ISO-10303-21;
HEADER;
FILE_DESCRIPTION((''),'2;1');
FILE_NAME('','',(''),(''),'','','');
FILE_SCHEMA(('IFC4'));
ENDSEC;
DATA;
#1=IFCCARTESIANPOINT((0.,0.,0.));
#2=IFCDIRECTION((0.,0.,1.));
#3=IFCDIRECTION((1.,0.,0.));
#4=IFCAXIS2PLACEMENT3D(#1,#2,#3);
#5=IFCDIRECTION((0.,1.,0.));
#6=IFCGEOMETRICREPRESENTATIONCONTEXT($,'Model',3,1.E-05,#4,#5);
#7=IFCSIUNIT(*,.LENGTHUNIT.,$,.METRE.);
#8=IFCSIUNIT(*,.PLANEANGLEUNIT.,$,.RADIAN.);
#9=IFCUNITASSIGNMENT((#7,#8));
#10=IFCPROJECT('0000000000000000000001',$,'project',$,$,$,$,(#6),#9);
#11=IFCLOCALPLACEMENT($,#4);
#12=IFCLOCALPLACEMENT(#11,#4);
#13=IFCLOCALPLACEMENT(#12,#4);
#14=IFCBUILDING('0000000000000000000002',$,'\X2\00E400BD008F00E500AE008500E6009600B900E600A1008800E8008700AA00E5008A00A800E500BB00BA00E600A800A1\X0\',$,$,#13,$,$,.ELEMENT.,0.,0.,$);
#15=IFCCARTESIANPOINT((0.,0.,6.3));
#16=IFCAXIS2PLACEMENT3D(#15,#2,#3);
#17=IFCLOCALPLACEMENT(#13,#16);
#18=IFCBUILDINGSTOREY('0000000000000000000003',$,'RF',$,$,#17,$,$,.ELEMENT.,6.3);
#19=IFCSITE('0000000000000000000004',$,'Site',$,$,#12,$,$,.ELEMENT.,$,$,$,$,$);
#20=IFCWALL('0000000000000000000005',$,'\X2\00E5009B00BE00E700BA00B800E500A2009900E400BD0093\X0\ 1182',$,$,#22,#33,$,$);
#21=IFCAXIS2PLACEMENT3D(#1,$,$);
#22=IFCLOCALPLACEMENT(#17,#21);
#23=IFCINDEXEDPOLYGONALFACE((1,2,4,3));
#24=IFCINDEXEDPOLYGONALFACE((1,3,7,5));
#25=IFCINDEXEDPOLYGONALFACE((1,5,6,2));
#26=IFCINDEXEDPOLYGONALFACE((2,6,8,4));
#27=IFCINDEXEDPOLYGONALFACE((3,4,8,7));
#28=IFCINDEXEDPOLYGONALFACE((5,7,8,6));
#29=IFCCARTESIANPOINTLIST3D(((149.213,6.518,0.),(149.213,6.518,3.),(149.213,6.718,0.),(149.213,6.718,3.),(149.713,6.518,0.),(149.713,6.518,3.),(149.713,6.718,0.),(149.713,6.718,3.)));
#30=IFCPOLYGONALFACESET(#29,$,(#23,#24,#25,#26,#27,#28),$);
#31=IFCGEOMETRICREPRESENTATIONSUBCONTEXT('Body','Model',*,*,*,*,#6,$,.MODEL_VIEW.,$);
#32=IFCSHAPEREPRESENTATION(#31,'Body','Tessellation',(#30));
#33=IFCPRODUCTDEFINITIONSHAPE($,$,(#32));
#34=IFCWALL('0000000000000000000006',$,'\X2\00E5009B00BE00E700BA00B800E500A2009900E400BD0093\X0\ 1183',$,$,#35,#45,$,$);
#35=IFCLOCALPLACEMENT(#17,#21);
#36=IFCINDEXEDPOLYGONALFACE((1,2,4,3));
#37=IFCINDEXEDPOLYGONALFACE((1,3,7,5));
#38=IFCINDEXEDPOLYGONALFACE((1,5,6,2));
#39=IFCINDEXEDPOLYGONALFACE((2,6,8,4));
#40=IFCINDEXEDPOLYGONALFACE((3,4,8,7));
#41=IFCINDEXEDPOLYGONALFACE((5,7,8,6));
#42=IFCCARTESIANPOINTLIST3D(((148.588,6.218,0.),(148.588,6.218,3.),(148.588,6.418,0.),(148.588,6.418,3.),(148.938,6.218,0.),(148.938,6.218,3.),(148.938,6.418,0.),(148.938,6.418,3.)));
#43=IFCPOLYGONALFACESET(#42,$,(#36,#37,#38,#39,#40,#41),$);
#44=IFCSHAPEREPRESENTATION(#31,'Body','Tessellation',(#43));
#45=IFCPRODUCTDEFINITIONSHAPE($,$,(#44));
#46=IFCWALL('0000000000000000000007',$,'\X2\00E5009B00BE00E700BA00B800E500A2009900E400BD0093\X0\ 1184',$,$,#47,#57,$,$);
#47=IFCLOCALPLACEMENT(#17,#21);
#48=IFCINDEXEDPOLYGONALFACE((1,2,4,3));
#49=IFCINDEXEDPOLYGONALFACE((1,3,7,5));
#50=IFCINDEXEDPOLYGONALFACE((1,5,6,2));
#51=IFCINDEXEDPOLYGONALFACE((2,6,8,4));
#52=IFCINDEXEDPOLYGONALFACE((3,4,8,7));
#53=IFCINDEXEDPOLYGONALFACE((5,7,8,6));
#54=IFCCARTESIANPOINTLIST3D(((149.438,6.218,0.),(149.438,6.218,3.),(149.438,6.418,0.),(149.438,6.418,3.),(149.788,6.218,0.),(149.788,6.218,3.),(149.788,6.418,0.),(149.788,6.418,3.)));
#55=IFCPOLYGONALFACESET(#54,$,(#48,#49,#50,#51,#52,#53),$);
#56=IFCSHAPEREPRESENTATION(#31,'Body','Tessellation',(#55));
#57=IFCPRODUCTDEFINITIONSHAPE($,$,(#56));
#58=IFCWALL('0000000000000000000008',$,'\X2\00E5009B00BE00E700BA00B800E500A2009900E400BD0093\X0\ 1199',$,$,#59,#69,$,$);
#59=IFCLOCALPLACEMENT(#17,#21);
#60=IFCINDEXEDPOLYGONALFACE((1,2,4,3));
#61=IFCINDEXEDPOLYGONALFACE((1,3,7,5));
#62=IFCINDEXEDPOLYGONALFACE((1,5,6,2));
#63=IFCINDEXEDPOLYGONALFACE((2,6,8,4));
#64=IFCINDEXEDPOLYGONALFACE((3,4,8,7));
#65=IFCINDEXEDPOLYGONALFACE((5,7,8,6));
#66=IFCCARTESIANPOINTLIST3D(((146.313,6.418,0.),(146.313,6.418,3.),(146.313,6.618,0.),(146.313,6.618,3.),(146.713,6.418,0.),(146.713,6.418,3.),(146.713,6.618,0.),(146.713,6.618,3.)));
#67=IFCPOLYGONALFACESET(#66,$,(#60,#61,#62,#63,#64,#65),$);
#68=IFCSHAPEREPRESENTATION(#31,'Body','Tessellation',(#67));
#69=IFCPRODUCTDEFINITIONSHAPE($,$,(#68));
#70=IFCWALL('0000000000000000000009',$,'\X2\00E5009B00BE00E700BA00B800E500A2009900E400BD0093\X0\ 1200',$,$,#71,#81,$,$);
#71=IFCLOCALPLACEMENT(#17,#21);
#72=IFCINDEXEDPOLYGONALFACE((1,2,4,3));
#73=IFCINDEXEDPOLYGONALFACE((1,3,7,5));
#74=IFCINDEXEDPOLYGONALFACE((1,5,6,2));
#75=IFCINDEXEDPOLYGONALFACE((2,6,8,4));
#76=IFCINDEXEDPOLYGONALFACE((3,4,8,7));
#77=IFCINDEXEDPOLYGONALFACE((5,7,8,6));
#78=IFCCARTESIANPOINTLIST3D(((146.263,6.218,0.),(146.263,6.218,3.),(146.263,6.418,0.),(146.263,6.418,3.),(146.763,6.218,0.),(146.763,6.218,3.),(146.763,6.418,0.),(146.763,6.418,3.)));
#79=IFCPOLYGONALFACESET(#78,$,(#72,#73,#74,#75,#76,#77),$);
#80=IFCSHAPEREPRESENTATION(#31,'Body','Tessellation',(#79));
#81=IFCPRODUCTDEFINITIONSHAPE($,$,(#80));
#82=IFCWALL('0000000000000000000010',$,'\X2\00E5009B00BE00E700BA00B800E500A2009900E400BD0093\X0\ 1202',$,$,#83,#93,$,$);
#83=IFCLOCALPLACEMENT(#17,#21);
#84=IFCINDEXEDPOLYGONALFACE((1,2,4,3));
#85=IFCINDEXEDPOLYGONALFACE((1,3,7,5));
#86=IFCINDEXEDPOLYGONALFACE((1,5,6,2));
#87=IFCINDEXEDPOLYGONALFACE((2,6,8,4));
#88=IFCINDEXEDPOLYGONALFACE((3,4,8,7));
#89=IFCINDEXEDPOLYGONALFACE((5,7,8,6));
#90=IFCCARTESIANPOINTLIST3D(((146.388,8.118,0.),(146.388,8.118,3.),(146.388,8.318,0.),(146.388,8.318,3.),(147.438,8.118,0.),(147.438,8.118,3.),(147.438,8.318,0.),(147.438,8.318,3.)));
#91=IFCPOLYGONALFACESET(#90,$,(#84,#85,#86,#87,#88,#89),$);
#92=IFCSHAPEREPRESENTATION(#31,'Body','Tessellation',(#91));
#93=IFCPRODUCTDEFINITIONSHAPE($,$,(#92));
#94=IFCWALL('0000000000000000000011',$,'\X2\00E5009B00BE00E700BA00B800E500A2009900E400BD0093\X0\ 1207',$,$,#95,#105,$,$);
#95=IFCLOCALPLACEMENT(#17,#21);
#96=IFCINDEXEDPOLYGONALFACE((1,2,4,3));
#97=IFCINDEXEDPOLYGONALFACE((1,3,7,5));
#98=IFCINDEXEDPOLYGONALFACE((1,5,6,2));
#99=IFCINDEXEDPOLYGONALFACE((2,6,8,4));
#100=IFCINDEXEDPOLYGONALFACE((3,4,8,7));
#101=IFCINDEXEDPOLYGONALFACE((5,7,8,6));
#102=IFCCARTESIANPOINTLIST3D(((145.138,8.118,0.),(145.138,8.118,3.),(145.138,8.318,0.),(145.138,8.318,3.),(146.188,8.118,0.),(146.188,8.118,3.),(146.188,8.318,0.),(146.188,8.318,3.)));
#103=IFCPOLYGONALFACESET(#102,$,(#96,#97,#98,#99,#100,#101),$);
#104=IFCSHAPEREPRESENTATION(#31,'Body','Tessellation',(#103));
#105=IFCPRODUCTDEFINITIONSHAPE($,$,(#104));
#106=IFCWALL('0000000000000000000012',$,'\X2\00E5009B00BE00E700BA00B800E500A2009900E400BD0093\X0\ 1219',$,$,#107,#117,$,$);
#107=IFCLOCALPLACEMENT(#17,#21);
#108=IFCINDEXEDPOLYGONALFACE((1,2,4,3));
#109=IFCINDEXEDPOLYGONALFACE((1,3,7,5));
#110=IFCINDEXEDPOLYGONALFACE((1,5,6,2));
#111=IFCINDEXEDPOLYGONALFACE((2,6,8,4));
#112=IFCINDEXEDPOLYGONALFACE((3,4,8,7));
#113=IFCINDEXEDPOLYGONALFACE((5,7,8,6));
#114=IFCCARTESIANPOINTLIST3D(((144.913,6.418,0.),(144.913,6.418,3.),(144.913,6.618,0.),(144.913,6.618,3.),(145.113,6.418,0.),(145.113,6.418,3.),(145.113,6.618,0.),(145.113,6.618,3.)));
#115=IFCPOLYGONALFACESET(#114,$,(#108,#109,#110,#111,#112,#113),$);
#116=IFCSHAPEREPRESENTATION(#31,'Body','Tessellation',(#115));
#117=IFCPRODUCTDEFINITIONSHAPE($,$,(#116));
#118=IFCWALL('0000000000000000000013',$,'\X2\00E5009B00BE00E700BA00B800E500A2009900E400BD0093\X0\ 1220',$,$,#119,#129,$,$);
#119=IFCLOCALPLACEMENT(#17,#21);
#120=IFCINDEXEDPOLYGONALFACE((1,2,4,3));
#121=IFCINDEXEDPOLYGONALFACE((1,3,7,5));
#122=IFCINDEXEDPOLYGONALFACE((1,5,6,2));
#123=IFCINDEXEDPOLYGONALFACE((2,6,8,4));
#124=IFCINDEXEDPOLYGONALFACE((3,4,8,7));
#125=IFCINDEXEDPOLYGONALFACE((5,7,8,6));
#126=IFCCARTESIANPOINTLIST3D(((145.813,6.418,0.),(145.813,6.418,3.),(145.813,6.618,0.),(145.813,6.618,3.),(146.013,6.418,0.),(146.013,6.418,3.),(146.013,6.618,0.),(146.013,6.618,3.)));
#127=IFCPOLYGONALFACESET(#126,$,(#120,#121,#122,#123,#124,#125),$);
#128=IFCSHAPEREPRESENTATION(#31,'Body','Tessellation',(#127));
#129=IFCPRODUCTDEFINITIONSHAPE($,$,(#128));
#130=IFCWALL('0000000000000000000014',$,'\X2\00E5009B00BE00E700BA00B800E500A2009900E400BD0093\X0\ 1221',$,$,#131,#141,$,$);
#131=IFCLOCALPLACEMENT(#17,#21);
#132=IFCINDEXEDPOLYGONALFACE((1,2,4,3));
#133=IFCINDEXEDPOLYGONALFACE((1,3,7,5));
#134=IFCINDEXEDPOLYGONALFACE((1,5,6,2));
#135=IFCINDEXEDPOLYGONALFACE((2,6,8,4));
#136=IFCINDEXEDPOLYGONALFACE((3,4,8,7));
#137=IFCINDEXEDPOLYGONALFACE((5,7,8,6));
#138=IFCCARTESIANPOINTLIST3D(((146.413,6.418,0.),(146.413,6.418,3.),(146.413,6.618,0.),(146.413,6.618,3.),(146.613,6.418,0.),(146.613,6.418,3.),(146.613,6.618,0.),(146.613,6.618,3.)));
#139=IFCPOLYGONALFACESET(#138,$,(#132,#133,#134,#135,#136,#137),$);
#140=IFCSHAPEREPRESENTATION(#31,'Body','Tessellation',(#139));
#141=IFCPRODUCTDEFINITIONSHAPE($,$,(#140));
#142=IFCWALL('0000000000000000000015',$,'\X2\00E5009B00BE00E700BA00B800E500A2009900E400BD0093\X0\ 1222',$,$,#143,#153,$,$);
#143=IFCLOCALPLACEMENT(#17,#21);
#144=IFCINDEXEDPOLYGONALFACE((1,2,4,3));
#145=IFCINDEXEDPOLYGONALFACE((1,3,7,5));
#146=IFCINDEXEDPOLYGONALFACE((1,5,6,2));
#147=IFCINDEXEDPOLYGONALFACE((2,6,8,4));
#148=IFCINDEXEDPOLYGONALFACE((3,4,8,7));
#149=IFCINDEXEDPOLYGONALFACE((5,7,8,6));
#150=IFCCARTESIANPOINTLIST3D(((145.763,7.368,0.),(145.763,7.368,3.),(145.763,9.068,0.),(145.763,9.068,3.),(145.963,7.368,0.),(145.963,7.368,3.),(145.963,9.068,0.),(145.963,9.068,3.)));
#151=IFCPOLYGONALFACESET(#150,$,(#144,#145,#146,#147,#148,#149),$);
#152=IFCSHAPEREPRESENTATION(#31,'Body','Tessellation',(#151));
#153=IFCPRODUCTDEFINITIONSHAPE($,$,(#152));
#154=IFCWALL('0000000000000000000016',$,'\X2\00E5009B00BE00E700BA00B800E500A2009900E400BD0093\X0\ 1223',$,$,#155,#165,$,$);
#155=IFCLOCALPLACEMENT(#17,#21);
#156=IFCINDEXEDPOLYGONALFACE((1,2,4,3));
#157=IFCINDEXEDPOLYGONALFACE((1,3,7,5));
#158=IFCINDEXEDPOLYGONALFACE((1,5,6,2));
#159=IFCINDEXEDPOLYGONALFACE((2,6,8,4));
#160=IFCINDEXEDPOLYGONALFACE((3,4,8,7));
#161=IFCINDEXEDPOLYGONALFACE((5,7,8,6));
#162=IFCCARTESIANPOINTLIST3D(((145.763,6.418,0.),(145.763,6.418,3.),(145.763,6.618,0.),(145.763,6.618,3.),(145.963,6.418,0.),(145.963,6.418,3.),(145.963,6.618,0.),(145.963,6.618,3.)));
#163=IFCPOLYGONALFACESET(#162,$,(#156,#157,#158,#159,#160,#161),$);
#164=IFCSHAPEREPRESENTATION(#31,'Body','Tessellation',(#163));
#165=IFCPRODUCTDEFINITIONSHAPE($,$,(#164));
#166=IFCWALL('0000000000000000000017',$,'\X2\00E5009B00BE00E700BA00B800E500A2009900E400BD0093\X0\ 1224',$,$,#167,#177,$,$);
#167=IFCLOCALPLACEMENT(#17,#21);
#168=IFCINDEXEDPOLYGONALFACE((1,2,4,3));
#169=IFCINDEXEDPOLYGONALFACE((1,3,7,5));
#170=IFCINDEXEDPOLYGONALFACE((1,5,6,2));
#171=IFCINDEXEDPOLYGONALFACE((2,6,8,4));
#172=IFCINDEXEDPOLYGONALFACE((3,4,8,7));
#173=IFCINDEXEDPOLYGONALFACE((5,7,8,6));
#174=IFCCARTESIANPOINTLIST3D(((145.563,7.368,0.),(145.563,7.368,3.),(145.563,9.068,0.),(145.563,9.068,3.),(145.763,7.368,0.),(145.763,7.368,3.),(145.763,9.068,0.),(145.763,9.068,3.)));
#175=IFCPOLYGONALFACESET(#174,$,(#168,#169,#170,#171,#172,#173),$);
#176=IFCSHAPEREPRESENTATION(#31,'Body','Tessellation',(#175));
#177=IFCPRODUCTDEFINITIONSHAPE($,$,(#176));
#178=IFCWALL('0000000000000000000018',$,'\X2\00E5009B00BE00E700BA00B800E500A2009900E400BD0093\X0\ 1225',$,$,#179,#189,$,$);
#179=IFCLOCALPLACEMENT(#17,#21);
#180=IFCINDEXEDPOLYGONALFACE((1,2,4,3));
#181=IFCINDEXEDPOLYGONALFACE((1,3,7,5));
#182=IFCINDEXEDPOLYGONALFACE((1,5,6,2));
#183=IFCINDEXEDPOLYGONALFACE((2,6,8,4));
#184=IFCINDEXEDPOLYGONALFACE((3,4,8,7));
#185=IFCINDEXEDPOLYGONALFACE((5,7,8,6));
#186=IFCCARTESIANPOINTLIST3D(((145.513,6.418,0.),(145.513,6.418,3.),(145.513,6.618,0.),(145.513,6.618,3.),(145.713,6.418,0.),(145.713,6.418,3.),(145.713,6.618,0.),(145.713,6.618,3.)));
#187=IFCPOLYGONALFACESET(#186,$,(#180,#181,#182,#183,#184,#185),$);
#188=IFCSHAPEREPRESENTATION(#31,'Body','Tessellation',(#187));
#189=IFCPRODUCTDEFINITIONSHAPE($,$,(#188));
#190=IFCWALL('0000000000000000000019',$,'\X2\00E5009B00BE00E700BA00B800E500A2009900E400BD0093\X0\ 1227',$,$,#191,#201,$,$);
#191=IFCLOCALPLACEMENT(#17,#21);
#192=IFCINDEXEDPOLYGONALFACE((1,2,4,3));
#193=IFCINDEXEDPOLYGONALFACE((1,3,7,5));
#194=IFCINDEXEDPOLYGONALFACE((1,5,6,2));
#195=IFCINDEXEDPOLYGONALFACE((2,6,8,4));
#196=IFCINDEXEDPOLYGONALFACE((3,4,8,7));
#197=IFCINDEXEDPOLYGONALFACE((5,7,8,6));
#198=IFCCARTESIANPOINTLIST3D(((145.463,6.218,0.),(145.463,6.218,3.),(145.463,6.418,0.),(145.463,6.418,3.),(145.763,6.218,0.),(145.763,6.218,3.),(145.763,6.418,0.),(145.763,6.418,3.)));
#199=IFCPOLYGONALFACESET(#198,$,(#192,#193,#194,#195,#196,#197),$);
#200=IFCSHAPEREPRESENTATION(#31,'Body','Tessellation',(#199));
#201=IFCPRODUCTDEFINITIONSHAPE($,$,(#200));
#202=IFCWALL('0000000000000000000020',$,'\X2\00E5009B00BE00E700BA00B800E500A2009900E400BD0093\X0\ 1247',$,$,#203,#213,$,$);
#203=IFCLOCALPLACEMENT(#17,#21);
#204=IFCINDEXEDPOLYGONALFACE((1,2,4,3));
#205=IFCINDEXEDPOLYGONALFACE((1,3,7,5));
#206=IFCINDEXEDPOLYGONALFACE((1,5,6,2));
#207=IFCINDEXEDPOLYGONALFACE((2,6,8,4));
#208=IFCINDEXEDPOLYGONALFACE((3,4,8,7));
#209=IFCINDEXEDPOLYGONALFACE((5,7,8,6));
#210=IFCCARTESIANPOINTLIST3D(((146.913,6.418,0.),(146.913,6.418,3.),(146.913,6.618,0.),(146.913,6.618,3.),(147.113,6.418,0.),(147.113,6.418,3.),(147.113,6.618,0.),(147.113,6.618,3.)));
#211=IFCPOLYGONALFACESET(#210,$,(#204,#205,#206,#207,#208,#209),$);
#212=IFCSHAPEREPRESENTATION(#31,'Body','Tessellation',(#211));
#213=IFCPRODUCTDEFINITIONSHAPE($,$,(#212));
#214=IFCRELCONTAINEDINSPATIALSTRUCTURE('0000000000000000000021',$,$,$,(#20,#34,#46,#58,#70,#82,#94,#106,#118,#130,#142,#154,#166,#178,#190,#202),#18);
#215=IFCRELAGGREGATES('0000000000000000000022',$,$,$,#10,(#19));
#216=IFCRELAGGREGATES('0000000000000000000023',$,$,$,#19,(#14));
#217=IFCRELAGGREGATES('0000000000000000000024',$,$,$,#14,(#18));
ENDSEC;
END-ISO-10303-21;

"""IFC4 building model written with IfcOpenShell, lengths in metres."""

from ifc_helpers import new_model, si_unit, direction, frame, frame_2d, origin_with_axes, place, context, subcontext, project, spatial, rectangle, extrude, element, save


model = new_model("IFC4")

# Units and contexts
model_context = context("Model", 3, precision=1e-05, world=origin_with_axes(), true_north=direction((0.0, 1.0, 0.0)))
body_context = subcontext(model_context, "Body", "Model", "MODEL_VIEW")
ifc_project = project(units=[si_unit("LENGTHUNIT", "METRE"), si_unit("PLANEANGLEUNIT", "RADIAN")], contexts=[model_context])

# Site, building, storey
placement = place(None, origin_with_axes())
site_placement = place(placement, origin_with_axes())
site = spatial("IfcSite", under=ifc_project, at=site_placement, Name="Site", CompositionType="ELEMENT")
building_placement = place(site_placement, origin_with_axes())
building = spatial("IfcBuilding", under=site, at=building_placement, Name="ä½\u008få®\u0085æ\u0096¹æ¡\u0088è\u0087ªå\u008a¨å»ºæ¨¡", CompositionType="ELEMENT", ElevationOfRefHeight=0.0, ElevationOfTerrain=0.0)
storey_placement = place(building_placement, frame((0.0, 0.0, 6.3), z_axis=(0.0, 0.0, 1.0), x_axis=(1.0, 0.0, 0.0)))
storey = spatial("IfcBuildingStorey", under=building, at=storey_placement, Name="RF", CompositionType="ELEMENT", Elevation=6.3)

# Walls
wall_1_placement = place(storey_placement, frame((149.463, 6.618, 0.0), z_axis=(0.0, 0.0, 1.0), x_axis=(1.0, 0.0, 0.0)))
element("IfcWall", 1, at=wall_1_placement, inside=storey, Name="å\u009b¾çº¸å¢\u0099ä½\u0093 1182", context=body_context, shape_type="SweptSolid", body=[
    extrude(rectangle(XDim=0.5, YDim=0.2, at=frame_2d((0.0, 0.0), x_axis=(1.0, 0.0, 0.0))), frame((0.0, 0.0, 0.0), z_axis=(0.0, 0.0, 1.0)), (0.0, 0.0, 1.0), 3.0),
])
for number, where, z_axis, x_axis, name in (
    (2, (148.763, 6.318, 0.0), (0.0, 0.0, 1.0), (1.0, 0.0, 0.0), "å\u009b¾çº¸å¢\u0099ä½\u0093 1183"),
    (3, (149.613, 6.318, 0.0), (0.0, 0.0, 1.0), (1.0, 0.0, 0.0), "å\u009b¾çº¸å¢\u0099ä½\u0093 1184"),
):
    element("IfcWall", number, at=place(storey_placement, frame(where, z_axis=z_axis, x_axis=x_axis)), inside=storey, Name=name, context=body_context, shape_type="SweptSolid", body=[
        extrude(rectangle(XDim=0.35, YDim=0.2, at=frame_2d((0.0, 0.0), x_axis=(1.0, 0.0, 0.0))), frame((0.0, 0.0, 0.0), z_axis=(0.0, 0.0, 1.0)), (0.0, 0.0, 1.0), 3.0),
    ])
wall_2_placement = place(storey_placement, frame((146.513, 6.518, 0.0), z_axis=(0.0, 0.0, 1.0), x_axis=(1.0, 0.0, 0.0)))
element("IfcWall", 4, at=wall_2_placement, inside=storey, Name="å\u009b¾çº¸å¢\u0099ä½\u0093 1199", context=body_context, shape_type="SweptSolid", body=[
    extrude(rectangle(XDim=0.4, YDim=0.2, at=frame_2d((0.0, 0.0), x_axis=(1.0, 0.0, 0.0))), frame((0.0, 0.0, 0.0), z_axis=(0.0, 0.0, 1.0)), (0.0, 0.0, 1.0), 3.0),
])
wall_3_placement = place(storey_placement, frame((146.513, 6.318, 0.0), z_axis=(0.0, 0.0, 1.0), x_axis=(1.0, 0.0, 0.0)))
element("IfcWall", 5, at=wall_3_placement, inside=storey, Name="å\u009b¾çº¸å¢\u0099ä½\u0093 1200", context=body_context, shape_type="SweptSolid", body=[
    extrude(rectangle(XDim=0.5, YDim=0.2, at=frame_2d((0.0, 0.0), x_axis=(1.0, 0.0, 0.0))), frame((0.0, 0.0, 0.0), z_axis=(0.0, 0.0, 1.0)), (0.0, 0.0, 1.0), 3.0),
])
for number, where, z_axis, x_axis, name in (
    (6, (146.913, 8.218, 0.0), (0.0, 0.0, 1.0), (-1.0, 0.0, 0.0), "å\u009b¾çº¸å¢\u0099ä½\u0093 1202"),
    (7, (145.663, 8.218, 0.0), (0.0, 0.0, 1.0), (-1.0, 0.0, 0.0), "å\u009b¾çº¸å¢\u0099ä½\u0093 1207"),
):
    element("IfcWall", number, at=place(storey_placement, frame(where, z_axis=z_axis, x_axis=x_axis)), inside=storey, Name=name, context=body_context, shape_type="SweptSolid", body=[
        extrude(rectangle(XDim=1.05, YDim=0.2, at=frame_2d((0.0, 0.0), x_axis=(1.0, 0.0, 0.0))), frame((0.0, 0.0, 0.0), z_axis=(0.0, 0.0, 1.0)), (0.0, 0.0, 1.0), 3.0),
    ])
for number, where, z_axis, x_axis, name in (
    (8, (145.013, 6.518, 0.0), (0.0, 0.0, 1.0), (0.0, -1.0, 0.0), "å\u009b¾çº¸å¢\u0099ä½\u0093 1219"),
    (9, (145.913, 6.518, 0.0), (0.0, 0.0, 1.0), (0.0, -1.0, 0.0), "å\u009b¾çº¸å¢\u0099ä½\u0093 1220"),
    (10, (146.513, 6.518, 0.0), (0.0, 0.0, 1.0), (0.0, -1.0, 0.0), "å\u009b¾çº¸å¢\u0099ä½\u0093 1221"),
):
    element("IfcWall", number, at=place(storey_placement, frame(where, z_axis=z_axis, x_axis=x_axis)), inside=storey, Name=name, context=body_context, shape_type="SweptSolid", body=[
        extrude(rectangle(XDim=0.2, YDim=0.2, at=frame_2d((0.0, 0.0), x_axis=(1.0, 0.0, 0.0))), frame((0.0, 0.0, 0.0), z_axis=(0.0, 0.0, 1.0)), (0.0, 0.0, 1.0), 3.0),
    ])
wall_4_placement = place(storey_placement, frame((145.863, 8.218, 0.0), z_axis=(0.0, 0.0, 1.0), x_axis=(0.0, -1.0, 0.0)))
element("IfcWall", 11, at=wall_4_placement, inside=storey, Name="å\u009b¾çº¸å¢\u0099ä½\u0093 1222", context=body_context, shape_type="SweptSolid", body=[
    extrude(rectangle(XDim=1.7, YDim=0.2, at=frame_2d((0.0, 0.0), x_axis=(1.0, 0.0, 0.0))), frame((0.0, 0.0, 0.0), z_axis=(0.0, 0.0, 1.0)), (0.0, 0.0, 1.0), 3.0),
])
wall_5_placement = place(storey_placement, frame((145.863, 6.518, 0.0), z_axis=(0.0, 0.0, 1.0), x_axis=(1.0, 0.0, 0.0)))
element("IfcWall", 12, at=wall_5_placement, inside=storey, Name="å\u009b¾çº¸å¢\u0099ä½\u0093 1223", context=body_context, shape_type="SweptSolid", body=[
    extrude(rectangle(XDim=0.2, YDim=0.2, at=frame_2d((0.0, 0.0), x_axis=(1.0, 0.0, 0.0))), frame((0.0, 0.0, 0.0), z_axis=(0.0, 0.0, 1.0)), (0.0, 0.0, 1.0), 3.0),
])
wall_6_placement = place(storey_placement, frame((145.663, 8.218, 0.0), z_axis=(0.0, 0.0, 1.0), x_axis=(0.0, -1.0, 0.0)))
element("IfcWall", 13, at=wall_6_placement, inside=storey, Name="å\u009b¾çº¸å¢\u0099ä½\u0093 1224", context=body_context, shape_type="SweptSolid", body=[
    extrude(rectangle(XDim=1.7, YDim=0.2, at=frame_2d((0.0, 0.0), x_axis=(1.0, 0.0, 0.0))), frame((0.0, 0.0, 0.0), z_axis=(0.0, 0.0, 1.0)), (0.0, 0.0, 1.0), 3.0),
])
for number, where, z_axis, x_axis, name in (
    (14, (145.613, 6.518, 0.0), (0.0, 0.0, 1.0), (1.0, 0.0, 0.0), "å\u009b¾çº¸å¢\u0099ä½\u0093 1225"),
):
    element("IfcWall", number, at=place(storey_placement, frame(where, z_axis=z_axis, x_axis=x_axis)), inside=storey, Name=name, context=body_context, shape_type="SweptSolid", body=[
        extrude(rectangle(XDim=0.2, YDim=0.2, at=frame_2d((0.0, 0.0), x_axis=(1.0, 0.0, 0.0))), frame((0.0, 0.0, 0.0), z_axis=(0.0, 0.0, 1.0)), (0.0, 0.0, 1.0), 3.0),
    ])
wall_7_placement = place(storey_placement, frame((145.613, 6.318, 0.0), z_axis=(0.0, 0.0, 1.0), x_axis=(1.0, 0.0, 0.0)))
element("IfcWall", 15, at=wall_7_placement, inside=storey, Name="å\u009b¾çº¸å¢\u0099ä½\u0093 1227", context=body_context, shape_type="SweptSolid", body=[
    extrude(rectangle(XDim=0.3, YDim=0.2, at=frame_2d((0.0, 0.0), x_axis=(1.0, 0.0, 0.0))), frame((0.0, 0.0, 0.0), z_axis=(0.0, 0.0, 1.0)), (0.0, 0.0, 1.0), 3.0),
])
for number, where, z_axis, x_axis, name in (
    (16, (147.013, 6.518, 0.0), (0.0, 0.0, 1.0), (0.0, -1.0, 0.0), "å\u009b¾çº¸å¢\u0099ä½\u0093 1247"),
):
    element("IfcWall", number, at=place(storey_placement, frame(where, z_axis=z_axis, x_axis=x_axis)), inside=storey, Name=name, context=body_context, shape_type="SweptSolid", body=[
        extrude(rectangle(XDim=0.2, YDim=0.2, at=frame_2d((0.0, 0.0), x_axis=(1.0, 0.0, 0.0))), frame((0.0, 0.0, 0.0), z_axis=(0.0, 0.0, 1.0)), (0.0, 0.0, 1.0), 3.0),
    ])

save(model, "model.ifc")
